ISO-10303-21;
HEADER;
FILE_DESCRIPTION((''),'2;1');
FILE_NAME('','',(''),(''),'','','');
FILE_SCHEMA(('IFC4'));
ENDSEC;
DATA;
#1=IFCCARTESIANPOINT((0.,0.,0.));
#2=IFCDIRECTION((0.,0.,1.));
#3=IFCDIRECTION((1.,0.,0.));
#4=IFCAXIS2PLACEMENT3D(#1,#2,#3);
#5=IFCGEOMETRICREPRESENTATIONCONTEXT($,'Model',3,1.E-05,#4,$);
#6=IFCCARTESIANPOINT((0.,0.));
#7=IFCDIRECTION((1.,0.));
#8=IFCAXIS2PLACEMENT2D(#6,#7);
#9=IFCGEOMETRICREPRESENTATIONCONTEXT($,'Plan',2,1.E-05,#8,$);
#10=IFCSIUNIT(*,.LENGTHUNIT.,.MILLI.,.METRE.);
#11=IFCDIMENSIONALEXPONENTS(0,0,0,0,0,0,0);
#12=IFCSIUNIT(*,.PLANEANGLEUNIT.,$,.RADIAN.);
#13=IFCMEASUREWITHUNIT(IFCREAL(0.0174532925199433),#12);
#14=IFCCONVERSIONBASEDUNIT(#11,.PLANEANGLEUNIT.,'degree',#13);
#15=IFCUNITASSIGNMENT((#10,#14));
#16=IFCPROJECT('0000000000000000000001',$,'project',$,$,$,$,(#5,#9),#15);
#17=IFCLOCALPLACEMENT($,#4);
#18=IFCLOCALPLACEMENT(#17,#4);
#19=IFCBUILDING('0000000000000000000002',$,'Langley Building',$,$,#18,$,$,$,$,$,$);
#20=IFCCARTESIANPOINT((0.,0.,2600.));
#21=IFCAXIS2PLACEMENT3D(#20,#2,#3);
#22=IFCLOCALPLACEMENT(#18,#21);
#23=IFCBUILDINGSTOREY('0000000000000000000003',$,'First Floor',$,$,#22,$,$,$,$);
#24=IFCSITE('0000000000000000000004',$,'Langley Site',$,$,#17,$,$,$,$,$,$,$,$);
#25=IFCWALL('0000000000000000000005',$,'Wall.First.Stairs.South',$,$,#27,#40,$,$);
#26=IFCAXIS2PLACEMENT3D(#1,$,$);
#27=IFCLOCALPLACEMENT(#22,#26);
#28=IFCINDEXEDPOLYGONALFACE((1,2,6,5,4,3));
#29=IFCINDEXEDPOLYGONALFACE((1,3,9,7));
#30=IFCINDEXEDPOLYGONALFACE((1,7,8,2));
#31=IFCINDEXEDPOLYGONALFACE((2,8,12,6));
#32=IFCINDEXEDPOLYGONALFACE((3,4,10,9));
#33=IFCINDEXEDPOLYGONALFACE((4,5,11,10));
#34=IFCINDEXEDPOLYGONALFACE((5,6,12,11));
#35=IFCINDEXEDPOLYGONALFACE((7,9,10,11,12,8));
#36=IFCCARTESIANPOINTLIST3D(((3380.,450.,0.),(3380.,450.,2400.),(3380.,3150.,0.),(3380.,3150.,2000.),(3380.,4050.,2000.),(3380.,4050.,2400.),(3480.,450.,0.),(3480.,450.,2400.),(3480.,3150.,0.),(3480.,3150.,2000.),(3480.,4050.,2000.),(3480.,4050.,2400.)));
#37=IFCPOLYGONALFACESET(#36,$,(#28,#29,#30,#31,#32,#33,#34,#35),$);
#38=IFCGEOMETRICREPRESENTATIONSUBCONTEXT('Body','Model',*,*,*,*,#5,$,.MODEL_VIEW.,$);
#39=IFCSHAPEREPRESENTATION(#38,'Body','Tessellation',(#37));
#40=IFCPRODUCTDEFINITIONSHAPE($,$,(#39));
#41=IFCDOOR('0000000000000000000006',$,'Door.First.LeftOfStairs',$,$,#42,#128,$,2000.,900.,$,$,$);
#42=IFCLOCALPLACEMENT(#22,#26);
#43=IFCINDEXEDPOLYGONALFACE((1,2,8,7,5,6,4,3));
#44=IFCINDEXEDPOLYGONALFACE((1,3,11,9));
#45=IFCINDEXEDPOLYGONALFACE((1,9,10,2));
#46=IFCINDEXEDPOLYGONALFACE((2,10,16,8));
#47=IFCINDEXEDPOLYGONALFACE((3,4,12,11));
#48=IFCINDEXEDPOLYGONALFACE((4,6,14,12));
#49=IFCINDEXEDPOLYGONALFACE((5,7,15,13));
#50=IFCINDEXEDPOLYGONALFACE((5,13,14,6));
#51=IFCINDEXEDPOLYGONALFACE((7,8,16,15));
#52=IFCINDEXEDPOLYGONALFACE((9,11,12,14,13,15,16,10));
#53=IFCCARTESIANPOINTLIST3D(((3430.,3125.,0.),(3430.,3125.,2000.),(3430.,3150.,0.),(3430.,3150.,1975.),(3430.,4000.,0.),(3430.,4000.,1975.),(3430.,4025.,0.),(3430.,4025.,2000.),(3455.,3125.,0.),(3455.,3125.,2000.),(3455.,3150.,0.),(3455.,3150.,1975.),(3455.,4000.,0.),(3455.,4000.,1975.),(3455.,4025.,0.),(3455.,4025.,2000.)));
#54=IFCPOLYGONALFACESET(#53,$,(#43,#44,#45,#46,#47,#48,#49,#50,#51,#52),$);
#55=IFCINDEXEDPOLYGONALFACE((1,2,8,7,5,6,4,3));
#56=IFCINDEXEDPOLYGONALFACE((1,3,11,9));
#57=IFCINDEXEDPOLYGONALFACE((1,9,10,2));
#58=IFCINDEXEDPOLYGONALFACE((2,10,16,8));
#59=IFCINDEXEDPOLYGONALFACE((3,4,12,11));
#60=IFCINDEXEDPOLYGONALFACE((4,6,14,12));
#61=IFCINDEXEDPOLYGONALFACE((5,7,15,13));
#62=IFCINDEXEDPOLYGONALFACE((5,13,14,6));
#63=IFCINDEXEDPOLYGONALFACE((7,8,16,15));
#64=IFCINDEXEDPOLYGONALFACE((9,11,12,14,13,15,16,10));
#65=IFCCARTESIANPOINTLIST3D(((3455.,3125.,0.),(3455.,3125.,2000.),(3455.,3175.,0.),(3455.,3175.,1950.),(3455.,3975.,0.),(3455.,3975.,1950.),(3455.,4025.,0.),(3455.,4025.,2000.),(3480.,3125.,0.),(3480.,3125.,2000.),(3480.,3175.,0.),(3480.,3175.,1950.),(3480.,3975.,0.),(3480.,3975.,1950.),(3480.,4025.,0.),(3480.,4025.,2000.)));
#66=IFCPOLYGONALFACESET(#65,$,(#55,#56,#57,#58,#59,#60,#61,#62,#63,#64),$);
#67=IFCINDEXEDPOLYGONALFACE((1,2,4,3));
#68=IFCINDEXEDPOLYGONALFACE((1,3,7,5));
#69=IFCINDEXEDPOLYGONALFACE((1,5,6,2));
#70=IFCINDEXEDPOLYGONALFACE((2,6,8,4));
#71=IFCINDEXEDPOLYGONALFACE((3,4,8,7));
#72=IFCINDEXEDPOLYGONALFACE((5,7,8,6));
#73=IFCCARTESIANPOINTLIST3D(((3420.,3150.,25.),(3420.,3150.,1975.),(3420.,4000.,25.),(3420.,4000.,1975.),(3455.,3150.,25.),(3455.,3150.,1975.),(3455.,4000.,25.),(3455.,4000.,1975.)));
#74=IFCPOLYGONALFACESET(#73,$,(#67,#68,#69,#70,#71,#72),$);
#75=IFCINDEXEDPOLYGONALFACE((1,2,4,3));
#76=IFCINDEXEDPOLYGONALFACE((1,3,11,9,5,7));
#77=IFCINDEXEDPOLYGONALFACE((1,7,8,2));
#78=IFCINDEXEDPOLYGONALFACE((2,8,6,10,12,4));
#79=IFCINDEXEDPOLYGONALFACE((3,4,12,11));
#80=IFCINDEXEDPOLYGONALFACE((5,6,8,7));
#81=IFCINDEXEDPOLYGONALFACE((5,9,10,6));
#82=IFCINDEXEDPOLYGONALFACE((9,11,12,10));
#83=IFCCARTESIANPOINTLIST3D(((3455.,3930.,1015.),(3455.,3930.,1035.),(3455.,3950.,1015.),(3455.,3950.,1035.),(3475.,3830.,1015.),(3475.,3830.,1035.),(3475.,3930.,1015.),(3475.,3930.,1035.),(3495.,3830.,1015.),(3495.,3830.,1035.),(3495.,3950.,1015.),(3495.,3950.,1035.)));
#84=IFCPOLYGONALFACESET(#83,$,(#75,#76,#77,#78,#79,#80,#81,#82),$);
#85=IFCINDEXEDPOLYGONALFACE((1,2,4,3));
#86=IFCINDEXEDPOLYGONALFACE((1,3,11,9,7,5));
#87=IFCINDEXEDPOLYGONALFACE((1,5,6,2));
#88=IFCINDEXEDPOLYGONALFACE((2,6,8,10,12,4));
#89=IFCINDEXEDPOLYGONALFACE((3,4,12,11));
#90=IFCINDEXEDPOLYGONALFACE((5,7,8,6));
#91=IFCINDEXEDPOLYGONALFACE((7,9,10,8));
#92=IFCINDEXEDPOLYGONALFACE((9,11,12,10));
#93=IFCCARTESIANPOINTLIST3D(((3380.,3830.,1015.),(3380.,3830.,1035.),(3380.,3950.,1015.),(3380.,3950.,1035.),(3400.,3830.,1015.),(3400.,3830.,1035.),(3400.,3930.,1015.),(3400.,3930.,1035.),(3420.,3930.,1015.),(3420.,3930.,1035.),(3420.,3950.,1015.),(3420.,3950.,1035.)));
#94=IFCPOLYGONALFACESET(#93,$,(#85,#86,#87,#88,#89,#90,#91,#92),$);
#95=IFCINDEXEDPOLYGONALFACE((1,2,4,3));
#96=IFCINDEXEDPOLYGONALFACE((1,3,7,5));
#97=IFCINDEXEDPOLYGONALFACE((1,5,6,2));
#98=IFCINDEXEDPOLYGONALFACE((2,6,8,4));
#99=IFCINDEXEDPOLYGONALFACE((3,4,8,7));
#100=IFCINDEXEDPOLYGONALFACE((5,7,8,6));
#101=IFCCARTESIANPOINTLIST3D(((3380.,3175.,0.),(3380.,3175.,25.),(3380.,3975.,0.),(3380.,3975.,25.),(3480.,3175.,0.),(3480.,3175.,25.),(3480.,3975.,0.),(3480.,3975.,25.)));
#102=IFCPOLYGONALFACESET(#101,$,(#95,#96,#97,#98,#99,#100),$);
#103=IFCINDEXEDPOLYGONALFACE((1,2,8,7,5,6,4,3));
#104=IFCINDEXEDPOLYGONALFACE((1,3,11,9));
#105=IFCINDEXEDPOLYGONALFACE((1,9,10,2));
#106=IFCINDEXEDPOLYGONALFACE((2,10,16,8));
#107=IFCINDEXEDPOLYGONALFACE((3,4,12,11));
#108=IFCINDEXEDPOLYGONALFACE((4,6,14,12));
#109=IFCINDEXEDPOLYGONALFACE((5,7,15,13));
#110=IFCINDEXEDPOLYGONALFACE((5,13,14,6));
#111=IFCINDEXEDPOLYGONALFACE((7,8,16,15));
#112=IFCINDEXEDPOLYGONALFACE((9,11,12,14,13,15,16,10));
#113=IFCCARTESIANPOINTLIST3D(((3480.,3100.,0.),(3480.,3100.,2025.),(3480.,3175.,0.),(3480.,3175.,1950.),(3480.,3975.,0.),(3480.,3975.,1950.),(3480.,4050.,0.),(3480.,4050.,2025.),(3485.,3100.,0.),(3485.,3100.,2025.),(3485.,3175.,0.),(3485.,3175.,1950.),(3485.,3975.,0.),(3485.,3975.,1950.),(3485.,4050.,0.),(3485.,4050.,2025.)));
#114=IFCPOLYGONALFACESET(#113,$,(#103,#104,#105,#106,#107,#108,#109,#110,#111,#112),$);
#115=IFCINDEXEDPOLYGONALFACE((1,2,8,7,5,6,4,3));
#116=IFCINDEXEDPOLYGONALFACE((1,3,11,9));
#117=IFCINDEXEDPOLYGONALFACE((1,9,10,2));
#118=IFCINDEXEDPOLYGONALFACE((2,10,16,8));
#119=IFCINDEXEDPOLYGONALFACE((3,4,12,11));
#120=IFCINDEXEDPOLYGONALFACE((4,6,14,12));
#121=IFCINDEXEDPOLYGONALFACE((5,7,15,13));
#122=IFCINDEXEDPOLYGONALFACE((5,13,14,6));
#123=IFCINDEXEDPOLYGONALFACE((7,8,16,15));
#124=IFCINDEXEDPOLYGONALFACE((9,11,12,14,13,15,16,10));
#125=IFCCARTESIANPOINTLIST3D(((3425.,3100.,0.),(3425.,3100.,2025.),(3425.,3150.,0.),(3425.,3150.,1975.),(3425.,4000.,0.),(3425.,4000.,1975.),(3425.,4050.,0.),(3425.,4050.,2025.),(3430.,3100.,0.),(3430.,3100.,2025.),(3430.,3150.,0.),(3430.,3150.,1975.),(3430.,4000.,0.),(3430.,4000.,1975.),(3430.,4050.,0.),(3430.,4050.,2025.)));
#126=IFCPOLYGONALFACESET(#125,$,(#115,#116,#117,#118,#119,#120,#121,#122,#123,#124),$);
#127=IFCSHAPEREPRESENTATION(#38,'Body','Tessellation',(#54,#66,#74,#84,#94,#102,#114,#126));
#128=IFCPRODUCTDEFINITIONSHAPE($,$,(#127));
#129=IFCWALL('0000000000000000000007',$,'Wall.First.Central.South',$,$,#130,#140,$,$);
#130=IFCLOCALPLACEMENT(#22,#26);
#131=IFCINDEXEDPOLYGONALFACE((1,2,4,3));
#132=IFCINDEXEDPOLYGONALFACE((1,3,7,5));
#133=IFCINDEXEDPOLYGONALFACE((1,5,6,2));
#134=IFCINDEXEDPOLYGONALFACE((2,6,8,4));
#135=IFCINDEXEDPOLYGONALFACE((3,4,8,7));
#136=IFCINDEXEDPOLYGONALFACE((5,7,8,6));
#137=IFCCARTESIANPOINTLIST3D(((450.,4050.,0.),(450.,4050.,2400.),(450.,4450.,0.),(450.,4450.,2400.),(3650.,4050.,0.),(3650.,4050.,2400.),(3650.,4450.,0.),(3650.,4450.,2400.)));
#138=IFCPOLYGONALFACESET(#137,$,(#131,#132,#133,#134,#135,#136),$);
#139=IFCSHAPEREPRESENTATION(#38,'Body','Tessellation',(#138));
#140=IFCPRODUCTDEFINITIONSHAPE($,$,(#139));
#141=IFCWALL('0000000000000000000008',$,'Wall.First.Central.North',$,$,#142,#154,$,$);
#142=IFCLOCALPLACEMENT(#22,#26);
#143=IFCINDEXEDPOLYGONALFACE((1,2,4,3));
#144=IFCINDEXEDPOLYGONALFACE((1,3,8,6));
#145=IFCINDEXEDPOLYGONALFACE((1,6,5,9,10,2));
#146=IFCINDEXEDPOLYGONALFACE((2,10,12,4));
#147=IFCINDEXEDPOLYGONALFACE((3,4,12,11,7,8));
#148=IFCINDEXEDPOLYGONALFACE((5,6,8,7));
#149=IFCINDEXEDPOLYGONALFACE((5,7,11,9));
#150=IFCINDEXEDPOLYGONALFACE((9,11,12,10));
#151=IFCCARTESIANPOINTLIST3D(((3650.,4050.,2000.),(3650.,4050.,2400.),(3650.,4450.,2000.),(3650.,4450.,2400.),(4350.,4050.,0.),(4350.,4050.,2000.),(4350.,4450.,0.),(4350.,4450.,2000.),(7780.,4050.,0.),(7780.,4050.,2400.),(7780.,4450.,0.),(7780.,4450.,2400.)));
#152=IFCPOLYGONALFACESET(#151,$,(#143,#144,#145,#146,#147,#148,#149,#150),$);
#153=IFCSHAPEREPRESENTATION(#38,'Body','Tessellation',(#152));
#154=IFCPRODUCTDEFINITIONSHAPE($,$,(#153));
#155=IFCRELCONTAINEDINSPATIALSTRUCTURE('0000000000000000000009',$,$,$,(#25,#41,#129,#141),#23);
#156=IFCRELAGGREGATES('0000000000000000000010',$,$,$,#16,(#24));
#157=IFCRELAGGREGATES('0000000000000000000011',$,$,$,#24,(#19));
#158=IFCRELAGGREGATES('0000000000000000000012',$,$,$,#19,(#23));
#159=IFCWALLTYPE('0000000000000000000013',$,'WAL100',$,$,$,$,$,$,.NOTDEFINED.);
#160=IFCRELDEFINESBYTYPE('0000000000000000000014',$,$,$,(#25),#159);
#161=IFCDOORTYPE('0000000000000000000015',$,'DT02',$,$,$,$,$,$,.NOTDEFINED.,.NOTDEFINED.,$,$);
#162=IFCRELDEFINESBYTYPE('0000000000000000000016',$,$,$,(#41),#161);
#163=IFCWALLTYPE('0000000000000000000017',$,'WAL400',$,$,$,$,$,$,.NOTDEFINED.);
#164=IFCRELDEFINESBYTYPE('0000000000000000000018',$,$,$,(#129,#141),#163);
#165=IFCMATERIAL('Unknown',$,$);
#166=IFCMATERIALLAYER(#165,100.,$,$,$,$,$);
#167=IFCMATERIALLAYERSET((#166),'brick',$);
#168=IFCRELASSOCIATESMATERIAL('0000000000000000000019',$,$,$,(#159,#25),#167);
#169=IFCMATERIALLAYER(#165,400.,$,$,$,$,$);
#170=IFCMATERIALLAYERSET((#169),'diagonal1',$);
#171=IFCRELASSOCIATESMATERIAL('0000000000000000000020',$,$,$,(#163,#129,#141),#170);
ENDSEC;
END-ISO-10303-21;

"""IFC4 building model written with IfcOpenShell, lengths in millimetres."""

from ifc_helpers import new_model, entity, si_unit, converted_unit, frame, origin_with_axes, origin_2d_with_axis, place, context, subcontext, project, spatial, line, indexed_curve, outline, extrude, shape, source, transform, mapped, material, layer, layer_set, layer_usage, type_object, type_shapes, element, fill, save


model = new_model("IFC4")

# Units and contexts
model_context = context("Model", 3, precision=1e-05, world=origin_with_axes())
plan_context = context("Plan", 2, precision=1e-05, world=origin_2d_with_axis())
body_context_1 = subcontext(model_context, "Body", "Model", "MODEL_VIEW")
body_context_2 = subcontext(plan_context, "Body", "Plan", "PLAN_VIEW")
ifc_project = project(units=[si_unit("LENGTHUNIT", "METRE", prefix="MILLI"), converted_unit("PLANEANGLEUNIT", "degree", entity("IfcReal", 0.0174532925199433), si_unit("PLANEANGLEUNIT", "RADIAN"), dimensions=[0, 0, 0, 0, 0, 0, 0])], contexts=[model_context, plan_context])

# Site, building, storey
site_placement = place(None, origin_with_axes())
site = spatial("IfcSite", under=ifc_project, at=site_placement, Name="Langley Site")
building_placement = place(site_placement, origin_with_axes())
building = spatial("IfcBuilding", under=site, at=building_placement, Name="Langley Building")
storey_placement = place(building_placement, frame((0.0, 0.0, 2600.0), z_axis=(0.0, 0.0, 1.0), x_axis=(1.0, 0.0, 0.0)))
storey = spatial("IfcBuildingStorey", under=building, at=storey_placement, Name="First Floor")

# Shared definitions
ifc_material = material(Name="Unknown")
shared_shape_1 = source(origin_with_axes(), body_context_1, "Body", "SweptSolid", [
    extrude(outline(indexed_curve([(0.0, 0.0), (900.0, 0.0), (900.0, 2000.0), (0.0, 2000.0)], segments=[line(1, 2, 3, 4, 1)])), frame((0.0, -600.0, 0.0), z_axis=(0.0, -1.0, 0.0), x_axis=(1.0, 0.0, 0.0)), (0.0, 0.0, -1.0), 1200.0),
])
door_type_1 = type_object("IfcDoorType", Name="DT02", OperationType="NOTDEFINED", PredefinedType="NOTDEFINED")
shared_shape_2 = source(origin_with_axes(), body_context_1, "Body", "SweptSolid", [
    extrude(outline(indexed_curve([(0.0, 0.0), (0.0, 2000.0), (900.0, 2000.0), (900.0, 0.0), (875.0, 0.0), (875.0, 1975.0), (25.0, 1975.0), (25.0, 0.0)], segments=[line(1, 2, 3, 4, 5, 6, 7, 8, 1)])), frame((0.0, 25.0, 0.0), z_axis=(0.0, -1.0, 0.0), x_axis=(1.0, 0.0, 0.0)), (0.0, 0.0, -1.0), 25.0),
    extrude(outline(indexed_curve([(0.0, 0.0), (0.0, 2000.0), (900.0, 2000.0), (900.0, 0.0), (850.0, 0.0), (850.0, 1950.0), (50.0, 1950.0), (50.0, 0.0)], segments=[line(1, 2, 3, 4, 5, 6, 7, 8, 1)])), frame((0.0, 0.0, 0.0), z_axis=(0.0, -1.0, 0.0), x_axis=(1.0, 0.0, 0.0)), (0.0, 0.0, -1.0), 25.0),
    extrude(outline(indexed_curve([(0.0, 0.0), (850.0, 0.0), (850.0, 35.0), (0.0, 35.0)], segments=[line(1, 2, 3, 4, 1)])), frame((25.0, 25.0, 25.0), z_axis=(0.0, 0.0, 1.0), x_axis=(1.0, 0.0, 0.0)), (0.0, 0.0, 1.0), 1950.0),
    extrude(outline(indexed_curve([(0.0, 0.0), (0.0, -40.0), (-120.0, -40.0), (-120.0, -20.0), (-20.0, -20.0), (-20.0, 0.0)], segments=[line(1, 2, 3, 4, 5, 6, 1)])), frame((825.0, 25.0, 1015.0), z_axis=(0.0, 0.0, 1.0), x_axis=(1.0, 0.0, 0.0)), (0.0, 0.0, 1.0), 20.0),
    extrude(outline(indexed_curve([(0.0, 0.0), (0.0, 40.0), (-120.0, 40.0), (-120.0, 20.0), (-20.0, 20.0), (-20.0, 0.0)], segments=[line(1, 2, 3, 4, 5, 6, 1)])), frame((825.0, 60.0, 1015.0), z_axis=(0.0, 0.0, 1.0), x_axis=(1.0, 0.0, 0.0)), (0.0, 0.0, 1.0), 20.0),
    extrude(outline(indexed_curve([(0.0, 0.0), (800.0, 0.0), (800.0, 100.0), (0.0, 100.0)], segments=[line(1, 2, 3, 4, 1)])), frame((50.0, 0.0, 0.0), z_axis=(0.0, 0.0, 1.0), x_axis=(1.0, 0.0, 0.0)), (0.0, 0.0, 1.0), 25.0),
    extrude(outline(indexed_curve([(0.0, 0.0), (0.0, 2025.0), (950.0, 2025.0), (950.0, 0.0), (875.0, 0.0), (875.0, 1950.0), (75.0, 1950.0), (75.0, 0.0)], segments=[line(1, 2, 3, 4, 5, 6, 7, 8, 1)])), frame((-25.0, -5.0, 0.0), z_axis=(0.0, -1.0, 0.0), x_axis=(1.0, 0.0, 0.0)), (0.0, 0.0, -1.0), 5.0),
    extrude(outline(indexed_curve([(0.0, 0.0), (0.0, 2025.0), (950.0, 2025.0), (950.0, 0.0), (900.0, 0.0), (900.0, 1975.0), (50.0, 1975.0), (50.0, 0.0)], segments=[line(1, 2, 3, 4, 5, 6, 7, 8, 1)])), frame((-25.0, 50.0, 0.0), z_axis=(0.0, -1.0, 0.0), x_axis=(1.0, 0.0, 0.0)), (0.0, 0.0, -1.0), 5.0),
])
shared_shape_3 = source(origin_with_axes(), body_context_2, "Body", "Curve2D", [
    entity("IfcIndexedPolyCurve", entity("IfcCartesianPointList2D", [[0.0, 0.0], [0.0, 50.0], [25.0, 50.0], [25.0, 25.0], [50.0, 25.0], [50.0, 0.0]]), [entity("IfcLineIndex", [1, 2, 3, 4, 5, 6, 1])]),
    entity("IfcIndexedPolyCurve", entity("IfcCartesianPointList2D", [[900.0, 0.0], [900.0, 50.0], [875.0, 50.0], [875.0, 25.0], [850.0, 25.0], [850.0, 0.0]]), [entity("IfcLineIndex", [1, 2, 3, 4, 5, 6, 1])]),
    entity("IfcTrimmedCurve", entity("IfcEllipse", entity("IfcAxis2Placement2D", entity("IfcCartesianPoint", [60.0, 50.0]), entity("IfcDirection", [1.0, 0.0])), 815.0, 850.0), [entity("IfcCartesianPoint", [875.0, 50.0])], [entity("IfcCartesianPoint", [60.0, 900.0])], True, "CARTESIAN"),
    entity("IfcIndexedPolyCurve", entity("IfcCartesianPointList2D", [[25.0, 50.0], [60.0, 50.0], [60.0, 900.0], [25.0, 900.0]]), [entity("IfcLineIndex", [1, 2, 3, 4, 1])]),
])
type_shapes(door_type_1, [shared_shape_2, shared_shape_3])

# Wall, opening, door
ifc_layer_1 = layer(ifc_material, 100.0)
ifc_layer_set_1 = layer_set([ifc_layer_1], Name="brick")
ifc_layer_usage_1 = layer_usage(ifc_layer_set_1, "AXIS2", "POSITIVE", 0.0)
wall_type_1 = type_object("IfcWallType", Name="WAL100", PredefinedType="NOTDEFINED", material=ifc_layer_set_1)
wall_1_placement = place(storey_placement, frame((3480.0, 450.0, 0.0), z_axis=(0.0, 0.0, 1.0), x_axis=(0.0, 1.0, 0.0)))
wall_1 = element("IfcWall", 1, at=wall_1_placement, inside=storey, type_object=wall_type_1, material=ifc_layer_usage_1, Name="Wall.First.Stairs.South", context=body_context_1, shape_type="SweptSolid", body=[
    extrude(outline(indexed_curve([(0.0, 0.0), (0.0, 100.0), (3600.0, 100.0), (3600.0, 0.0)], segments=[line(1, 2, 3, 4, 1)])), origin_with_axes(), (0.0, 0.0, 1.0), 2400.0),
])
opening_1_placement = place(wall_1_placement, frame((2700.0, 0.0, 0.0), z_axis=(0.0, 0.0, 1.0), x_axis=(1.0, 0.0, 0.0)))
opening_1 = element("IfcOpeningElement", 2, at=opening_1_placement, cuts=wall_1, PredefinedType="OPENING", context=body_context_1, shape_type="MappedRepresentation", body=[
    mapped(shared_shape_1, transform((0.0, 0.0, 0.0), x_axis=(1.0, 0.0, 0.0), y_axis=(0.0, 1.0, 0.0), z_axis=(0.0, 0.0, 1.0), scale=1.0)),
])
door_1_placement = place(opening_1_placement, frame((-25.0, 0.0, 0.0), z_axis=(0.0, 0.0, 1.0), x_axis=(1.0, 0.0, 0.0)))
door_1 = element("IfcDoor", 3, at=door_1_placement, inside=storey, type_object=door_type_1, Name="Door.First.LeftOfStairs", OverallHeight=2000.0, OverallWidth=900.0, shapes=[
    shape(body_context_1, "Body", "MappedRepresentation", [mapped(shared_shape_2, transform((0.0, 0.0, 0.0), x_axis=(1.0, 0.0, 0.0), y_axis=(0.0, 1.0, 0.0), z_axis=(0.0, 0.0, 1.0), scale=1.0))]),
    shape(body_context_2, "Body", "MappedRepresentation", [mapped(shared_shape_3, transform((0.0, 0.0, 0.0), x_axis=(1.0, 0.0, 0.0), y_axis=(0.0, 1.0, 0.0), z_axis=(0.0, 0.0, 1.0), scale=1.0))]),
])
fill(opening_1, door_1)

# Wall
ifc_layer_2 = layer(ifc_material, 400.0)
ifc_layer_set_2 = layer_set([ifc_layer_2], Name="diagonal1")
ifc_layer_usage_2 = layer_usage(ifc_layer_set_2, "AXIS2", "POSITIVE", 0.0)
wall_type_2 = type_object("IfcWallType", Name="WAL400", PredefinedType="NOTDEFINED", material=ifc_layer_set_2)
wall_2_placement = place(storey_placement, frame((450.0, 4050.0, 0.0), z_axis=(0.0, 0.0, 1.0), x_axis=(1.0, 0.0, 0.0)))
element("IfcWall", 4, at=wall_2_placement, inside=storey, type_object=wall_type_2, material=ifc_layer_usage_2, Name="Wall.First.Central.South", context=body_context_1, shape_type="SweptSolid", body=[
    extrude(outline(indexed_curve([(0.0, 0.0), (0.0, 400.0), (3200.0, 400.0), (3200.0, 0.0)], segments=[line(1, 2, 3, 4, 1)])), origin_with_axes(), (0.0, 0.0, 1.0), 2400.0),
])

# Wall, opening
ifc_layer_usage_3 = layer_usage(ifc_layer_set_2, "AXIS2", "POSITIVE", 0.0)
wall_3_placement = place(storey_placement, frame((3650.0, 4050.0, 0.0), z_axis=(0.0, 0.0, 1.0), x_axis=(1.0, 0.0, 0.0)))
wall_3 = element("IfcWall", 5, at=wall_3_placement, inside=storey, type_object=wall_type_2, material=ifc_layer_usage_3, Name="Wall.First.Central.North", context=body_context_1, shape_type="SweptSolid", body=[
    extrude(outline(indexed_curve([(0.0, 0.0), (0.0, 400.0), (4130.0, 400.0), (4130.0, 0.0)], segments=[line(1, 2, 3, 4, 1)])), origin_with_axes(), (0.0, 0.0, 1.0), 2400.0),
])
opening_2_placement = place(wall_3_placement, frame((0.0, 0.0, 0.0), z_axis=(0.0, 0.0, 1.0), x_axis=(1.0, 0.0, 0.0)))
element("IfcOpeningElement", 6, at=opening_2_placement, cuts=wall_3, PredefinedType="OPENING", context=body_context_1, shape_type="SweptSolid", body=[
    extrude(outline(indexed_curve([(0.0, 0.0), (700.0, 0.0), (700.0, 500.0), (0.0, 500.0), (0.0, 0.0)])), origin_with_axes(), (0.0, 0.0, 1.0), 2000.0),
])

save(model, "model.ifc")
